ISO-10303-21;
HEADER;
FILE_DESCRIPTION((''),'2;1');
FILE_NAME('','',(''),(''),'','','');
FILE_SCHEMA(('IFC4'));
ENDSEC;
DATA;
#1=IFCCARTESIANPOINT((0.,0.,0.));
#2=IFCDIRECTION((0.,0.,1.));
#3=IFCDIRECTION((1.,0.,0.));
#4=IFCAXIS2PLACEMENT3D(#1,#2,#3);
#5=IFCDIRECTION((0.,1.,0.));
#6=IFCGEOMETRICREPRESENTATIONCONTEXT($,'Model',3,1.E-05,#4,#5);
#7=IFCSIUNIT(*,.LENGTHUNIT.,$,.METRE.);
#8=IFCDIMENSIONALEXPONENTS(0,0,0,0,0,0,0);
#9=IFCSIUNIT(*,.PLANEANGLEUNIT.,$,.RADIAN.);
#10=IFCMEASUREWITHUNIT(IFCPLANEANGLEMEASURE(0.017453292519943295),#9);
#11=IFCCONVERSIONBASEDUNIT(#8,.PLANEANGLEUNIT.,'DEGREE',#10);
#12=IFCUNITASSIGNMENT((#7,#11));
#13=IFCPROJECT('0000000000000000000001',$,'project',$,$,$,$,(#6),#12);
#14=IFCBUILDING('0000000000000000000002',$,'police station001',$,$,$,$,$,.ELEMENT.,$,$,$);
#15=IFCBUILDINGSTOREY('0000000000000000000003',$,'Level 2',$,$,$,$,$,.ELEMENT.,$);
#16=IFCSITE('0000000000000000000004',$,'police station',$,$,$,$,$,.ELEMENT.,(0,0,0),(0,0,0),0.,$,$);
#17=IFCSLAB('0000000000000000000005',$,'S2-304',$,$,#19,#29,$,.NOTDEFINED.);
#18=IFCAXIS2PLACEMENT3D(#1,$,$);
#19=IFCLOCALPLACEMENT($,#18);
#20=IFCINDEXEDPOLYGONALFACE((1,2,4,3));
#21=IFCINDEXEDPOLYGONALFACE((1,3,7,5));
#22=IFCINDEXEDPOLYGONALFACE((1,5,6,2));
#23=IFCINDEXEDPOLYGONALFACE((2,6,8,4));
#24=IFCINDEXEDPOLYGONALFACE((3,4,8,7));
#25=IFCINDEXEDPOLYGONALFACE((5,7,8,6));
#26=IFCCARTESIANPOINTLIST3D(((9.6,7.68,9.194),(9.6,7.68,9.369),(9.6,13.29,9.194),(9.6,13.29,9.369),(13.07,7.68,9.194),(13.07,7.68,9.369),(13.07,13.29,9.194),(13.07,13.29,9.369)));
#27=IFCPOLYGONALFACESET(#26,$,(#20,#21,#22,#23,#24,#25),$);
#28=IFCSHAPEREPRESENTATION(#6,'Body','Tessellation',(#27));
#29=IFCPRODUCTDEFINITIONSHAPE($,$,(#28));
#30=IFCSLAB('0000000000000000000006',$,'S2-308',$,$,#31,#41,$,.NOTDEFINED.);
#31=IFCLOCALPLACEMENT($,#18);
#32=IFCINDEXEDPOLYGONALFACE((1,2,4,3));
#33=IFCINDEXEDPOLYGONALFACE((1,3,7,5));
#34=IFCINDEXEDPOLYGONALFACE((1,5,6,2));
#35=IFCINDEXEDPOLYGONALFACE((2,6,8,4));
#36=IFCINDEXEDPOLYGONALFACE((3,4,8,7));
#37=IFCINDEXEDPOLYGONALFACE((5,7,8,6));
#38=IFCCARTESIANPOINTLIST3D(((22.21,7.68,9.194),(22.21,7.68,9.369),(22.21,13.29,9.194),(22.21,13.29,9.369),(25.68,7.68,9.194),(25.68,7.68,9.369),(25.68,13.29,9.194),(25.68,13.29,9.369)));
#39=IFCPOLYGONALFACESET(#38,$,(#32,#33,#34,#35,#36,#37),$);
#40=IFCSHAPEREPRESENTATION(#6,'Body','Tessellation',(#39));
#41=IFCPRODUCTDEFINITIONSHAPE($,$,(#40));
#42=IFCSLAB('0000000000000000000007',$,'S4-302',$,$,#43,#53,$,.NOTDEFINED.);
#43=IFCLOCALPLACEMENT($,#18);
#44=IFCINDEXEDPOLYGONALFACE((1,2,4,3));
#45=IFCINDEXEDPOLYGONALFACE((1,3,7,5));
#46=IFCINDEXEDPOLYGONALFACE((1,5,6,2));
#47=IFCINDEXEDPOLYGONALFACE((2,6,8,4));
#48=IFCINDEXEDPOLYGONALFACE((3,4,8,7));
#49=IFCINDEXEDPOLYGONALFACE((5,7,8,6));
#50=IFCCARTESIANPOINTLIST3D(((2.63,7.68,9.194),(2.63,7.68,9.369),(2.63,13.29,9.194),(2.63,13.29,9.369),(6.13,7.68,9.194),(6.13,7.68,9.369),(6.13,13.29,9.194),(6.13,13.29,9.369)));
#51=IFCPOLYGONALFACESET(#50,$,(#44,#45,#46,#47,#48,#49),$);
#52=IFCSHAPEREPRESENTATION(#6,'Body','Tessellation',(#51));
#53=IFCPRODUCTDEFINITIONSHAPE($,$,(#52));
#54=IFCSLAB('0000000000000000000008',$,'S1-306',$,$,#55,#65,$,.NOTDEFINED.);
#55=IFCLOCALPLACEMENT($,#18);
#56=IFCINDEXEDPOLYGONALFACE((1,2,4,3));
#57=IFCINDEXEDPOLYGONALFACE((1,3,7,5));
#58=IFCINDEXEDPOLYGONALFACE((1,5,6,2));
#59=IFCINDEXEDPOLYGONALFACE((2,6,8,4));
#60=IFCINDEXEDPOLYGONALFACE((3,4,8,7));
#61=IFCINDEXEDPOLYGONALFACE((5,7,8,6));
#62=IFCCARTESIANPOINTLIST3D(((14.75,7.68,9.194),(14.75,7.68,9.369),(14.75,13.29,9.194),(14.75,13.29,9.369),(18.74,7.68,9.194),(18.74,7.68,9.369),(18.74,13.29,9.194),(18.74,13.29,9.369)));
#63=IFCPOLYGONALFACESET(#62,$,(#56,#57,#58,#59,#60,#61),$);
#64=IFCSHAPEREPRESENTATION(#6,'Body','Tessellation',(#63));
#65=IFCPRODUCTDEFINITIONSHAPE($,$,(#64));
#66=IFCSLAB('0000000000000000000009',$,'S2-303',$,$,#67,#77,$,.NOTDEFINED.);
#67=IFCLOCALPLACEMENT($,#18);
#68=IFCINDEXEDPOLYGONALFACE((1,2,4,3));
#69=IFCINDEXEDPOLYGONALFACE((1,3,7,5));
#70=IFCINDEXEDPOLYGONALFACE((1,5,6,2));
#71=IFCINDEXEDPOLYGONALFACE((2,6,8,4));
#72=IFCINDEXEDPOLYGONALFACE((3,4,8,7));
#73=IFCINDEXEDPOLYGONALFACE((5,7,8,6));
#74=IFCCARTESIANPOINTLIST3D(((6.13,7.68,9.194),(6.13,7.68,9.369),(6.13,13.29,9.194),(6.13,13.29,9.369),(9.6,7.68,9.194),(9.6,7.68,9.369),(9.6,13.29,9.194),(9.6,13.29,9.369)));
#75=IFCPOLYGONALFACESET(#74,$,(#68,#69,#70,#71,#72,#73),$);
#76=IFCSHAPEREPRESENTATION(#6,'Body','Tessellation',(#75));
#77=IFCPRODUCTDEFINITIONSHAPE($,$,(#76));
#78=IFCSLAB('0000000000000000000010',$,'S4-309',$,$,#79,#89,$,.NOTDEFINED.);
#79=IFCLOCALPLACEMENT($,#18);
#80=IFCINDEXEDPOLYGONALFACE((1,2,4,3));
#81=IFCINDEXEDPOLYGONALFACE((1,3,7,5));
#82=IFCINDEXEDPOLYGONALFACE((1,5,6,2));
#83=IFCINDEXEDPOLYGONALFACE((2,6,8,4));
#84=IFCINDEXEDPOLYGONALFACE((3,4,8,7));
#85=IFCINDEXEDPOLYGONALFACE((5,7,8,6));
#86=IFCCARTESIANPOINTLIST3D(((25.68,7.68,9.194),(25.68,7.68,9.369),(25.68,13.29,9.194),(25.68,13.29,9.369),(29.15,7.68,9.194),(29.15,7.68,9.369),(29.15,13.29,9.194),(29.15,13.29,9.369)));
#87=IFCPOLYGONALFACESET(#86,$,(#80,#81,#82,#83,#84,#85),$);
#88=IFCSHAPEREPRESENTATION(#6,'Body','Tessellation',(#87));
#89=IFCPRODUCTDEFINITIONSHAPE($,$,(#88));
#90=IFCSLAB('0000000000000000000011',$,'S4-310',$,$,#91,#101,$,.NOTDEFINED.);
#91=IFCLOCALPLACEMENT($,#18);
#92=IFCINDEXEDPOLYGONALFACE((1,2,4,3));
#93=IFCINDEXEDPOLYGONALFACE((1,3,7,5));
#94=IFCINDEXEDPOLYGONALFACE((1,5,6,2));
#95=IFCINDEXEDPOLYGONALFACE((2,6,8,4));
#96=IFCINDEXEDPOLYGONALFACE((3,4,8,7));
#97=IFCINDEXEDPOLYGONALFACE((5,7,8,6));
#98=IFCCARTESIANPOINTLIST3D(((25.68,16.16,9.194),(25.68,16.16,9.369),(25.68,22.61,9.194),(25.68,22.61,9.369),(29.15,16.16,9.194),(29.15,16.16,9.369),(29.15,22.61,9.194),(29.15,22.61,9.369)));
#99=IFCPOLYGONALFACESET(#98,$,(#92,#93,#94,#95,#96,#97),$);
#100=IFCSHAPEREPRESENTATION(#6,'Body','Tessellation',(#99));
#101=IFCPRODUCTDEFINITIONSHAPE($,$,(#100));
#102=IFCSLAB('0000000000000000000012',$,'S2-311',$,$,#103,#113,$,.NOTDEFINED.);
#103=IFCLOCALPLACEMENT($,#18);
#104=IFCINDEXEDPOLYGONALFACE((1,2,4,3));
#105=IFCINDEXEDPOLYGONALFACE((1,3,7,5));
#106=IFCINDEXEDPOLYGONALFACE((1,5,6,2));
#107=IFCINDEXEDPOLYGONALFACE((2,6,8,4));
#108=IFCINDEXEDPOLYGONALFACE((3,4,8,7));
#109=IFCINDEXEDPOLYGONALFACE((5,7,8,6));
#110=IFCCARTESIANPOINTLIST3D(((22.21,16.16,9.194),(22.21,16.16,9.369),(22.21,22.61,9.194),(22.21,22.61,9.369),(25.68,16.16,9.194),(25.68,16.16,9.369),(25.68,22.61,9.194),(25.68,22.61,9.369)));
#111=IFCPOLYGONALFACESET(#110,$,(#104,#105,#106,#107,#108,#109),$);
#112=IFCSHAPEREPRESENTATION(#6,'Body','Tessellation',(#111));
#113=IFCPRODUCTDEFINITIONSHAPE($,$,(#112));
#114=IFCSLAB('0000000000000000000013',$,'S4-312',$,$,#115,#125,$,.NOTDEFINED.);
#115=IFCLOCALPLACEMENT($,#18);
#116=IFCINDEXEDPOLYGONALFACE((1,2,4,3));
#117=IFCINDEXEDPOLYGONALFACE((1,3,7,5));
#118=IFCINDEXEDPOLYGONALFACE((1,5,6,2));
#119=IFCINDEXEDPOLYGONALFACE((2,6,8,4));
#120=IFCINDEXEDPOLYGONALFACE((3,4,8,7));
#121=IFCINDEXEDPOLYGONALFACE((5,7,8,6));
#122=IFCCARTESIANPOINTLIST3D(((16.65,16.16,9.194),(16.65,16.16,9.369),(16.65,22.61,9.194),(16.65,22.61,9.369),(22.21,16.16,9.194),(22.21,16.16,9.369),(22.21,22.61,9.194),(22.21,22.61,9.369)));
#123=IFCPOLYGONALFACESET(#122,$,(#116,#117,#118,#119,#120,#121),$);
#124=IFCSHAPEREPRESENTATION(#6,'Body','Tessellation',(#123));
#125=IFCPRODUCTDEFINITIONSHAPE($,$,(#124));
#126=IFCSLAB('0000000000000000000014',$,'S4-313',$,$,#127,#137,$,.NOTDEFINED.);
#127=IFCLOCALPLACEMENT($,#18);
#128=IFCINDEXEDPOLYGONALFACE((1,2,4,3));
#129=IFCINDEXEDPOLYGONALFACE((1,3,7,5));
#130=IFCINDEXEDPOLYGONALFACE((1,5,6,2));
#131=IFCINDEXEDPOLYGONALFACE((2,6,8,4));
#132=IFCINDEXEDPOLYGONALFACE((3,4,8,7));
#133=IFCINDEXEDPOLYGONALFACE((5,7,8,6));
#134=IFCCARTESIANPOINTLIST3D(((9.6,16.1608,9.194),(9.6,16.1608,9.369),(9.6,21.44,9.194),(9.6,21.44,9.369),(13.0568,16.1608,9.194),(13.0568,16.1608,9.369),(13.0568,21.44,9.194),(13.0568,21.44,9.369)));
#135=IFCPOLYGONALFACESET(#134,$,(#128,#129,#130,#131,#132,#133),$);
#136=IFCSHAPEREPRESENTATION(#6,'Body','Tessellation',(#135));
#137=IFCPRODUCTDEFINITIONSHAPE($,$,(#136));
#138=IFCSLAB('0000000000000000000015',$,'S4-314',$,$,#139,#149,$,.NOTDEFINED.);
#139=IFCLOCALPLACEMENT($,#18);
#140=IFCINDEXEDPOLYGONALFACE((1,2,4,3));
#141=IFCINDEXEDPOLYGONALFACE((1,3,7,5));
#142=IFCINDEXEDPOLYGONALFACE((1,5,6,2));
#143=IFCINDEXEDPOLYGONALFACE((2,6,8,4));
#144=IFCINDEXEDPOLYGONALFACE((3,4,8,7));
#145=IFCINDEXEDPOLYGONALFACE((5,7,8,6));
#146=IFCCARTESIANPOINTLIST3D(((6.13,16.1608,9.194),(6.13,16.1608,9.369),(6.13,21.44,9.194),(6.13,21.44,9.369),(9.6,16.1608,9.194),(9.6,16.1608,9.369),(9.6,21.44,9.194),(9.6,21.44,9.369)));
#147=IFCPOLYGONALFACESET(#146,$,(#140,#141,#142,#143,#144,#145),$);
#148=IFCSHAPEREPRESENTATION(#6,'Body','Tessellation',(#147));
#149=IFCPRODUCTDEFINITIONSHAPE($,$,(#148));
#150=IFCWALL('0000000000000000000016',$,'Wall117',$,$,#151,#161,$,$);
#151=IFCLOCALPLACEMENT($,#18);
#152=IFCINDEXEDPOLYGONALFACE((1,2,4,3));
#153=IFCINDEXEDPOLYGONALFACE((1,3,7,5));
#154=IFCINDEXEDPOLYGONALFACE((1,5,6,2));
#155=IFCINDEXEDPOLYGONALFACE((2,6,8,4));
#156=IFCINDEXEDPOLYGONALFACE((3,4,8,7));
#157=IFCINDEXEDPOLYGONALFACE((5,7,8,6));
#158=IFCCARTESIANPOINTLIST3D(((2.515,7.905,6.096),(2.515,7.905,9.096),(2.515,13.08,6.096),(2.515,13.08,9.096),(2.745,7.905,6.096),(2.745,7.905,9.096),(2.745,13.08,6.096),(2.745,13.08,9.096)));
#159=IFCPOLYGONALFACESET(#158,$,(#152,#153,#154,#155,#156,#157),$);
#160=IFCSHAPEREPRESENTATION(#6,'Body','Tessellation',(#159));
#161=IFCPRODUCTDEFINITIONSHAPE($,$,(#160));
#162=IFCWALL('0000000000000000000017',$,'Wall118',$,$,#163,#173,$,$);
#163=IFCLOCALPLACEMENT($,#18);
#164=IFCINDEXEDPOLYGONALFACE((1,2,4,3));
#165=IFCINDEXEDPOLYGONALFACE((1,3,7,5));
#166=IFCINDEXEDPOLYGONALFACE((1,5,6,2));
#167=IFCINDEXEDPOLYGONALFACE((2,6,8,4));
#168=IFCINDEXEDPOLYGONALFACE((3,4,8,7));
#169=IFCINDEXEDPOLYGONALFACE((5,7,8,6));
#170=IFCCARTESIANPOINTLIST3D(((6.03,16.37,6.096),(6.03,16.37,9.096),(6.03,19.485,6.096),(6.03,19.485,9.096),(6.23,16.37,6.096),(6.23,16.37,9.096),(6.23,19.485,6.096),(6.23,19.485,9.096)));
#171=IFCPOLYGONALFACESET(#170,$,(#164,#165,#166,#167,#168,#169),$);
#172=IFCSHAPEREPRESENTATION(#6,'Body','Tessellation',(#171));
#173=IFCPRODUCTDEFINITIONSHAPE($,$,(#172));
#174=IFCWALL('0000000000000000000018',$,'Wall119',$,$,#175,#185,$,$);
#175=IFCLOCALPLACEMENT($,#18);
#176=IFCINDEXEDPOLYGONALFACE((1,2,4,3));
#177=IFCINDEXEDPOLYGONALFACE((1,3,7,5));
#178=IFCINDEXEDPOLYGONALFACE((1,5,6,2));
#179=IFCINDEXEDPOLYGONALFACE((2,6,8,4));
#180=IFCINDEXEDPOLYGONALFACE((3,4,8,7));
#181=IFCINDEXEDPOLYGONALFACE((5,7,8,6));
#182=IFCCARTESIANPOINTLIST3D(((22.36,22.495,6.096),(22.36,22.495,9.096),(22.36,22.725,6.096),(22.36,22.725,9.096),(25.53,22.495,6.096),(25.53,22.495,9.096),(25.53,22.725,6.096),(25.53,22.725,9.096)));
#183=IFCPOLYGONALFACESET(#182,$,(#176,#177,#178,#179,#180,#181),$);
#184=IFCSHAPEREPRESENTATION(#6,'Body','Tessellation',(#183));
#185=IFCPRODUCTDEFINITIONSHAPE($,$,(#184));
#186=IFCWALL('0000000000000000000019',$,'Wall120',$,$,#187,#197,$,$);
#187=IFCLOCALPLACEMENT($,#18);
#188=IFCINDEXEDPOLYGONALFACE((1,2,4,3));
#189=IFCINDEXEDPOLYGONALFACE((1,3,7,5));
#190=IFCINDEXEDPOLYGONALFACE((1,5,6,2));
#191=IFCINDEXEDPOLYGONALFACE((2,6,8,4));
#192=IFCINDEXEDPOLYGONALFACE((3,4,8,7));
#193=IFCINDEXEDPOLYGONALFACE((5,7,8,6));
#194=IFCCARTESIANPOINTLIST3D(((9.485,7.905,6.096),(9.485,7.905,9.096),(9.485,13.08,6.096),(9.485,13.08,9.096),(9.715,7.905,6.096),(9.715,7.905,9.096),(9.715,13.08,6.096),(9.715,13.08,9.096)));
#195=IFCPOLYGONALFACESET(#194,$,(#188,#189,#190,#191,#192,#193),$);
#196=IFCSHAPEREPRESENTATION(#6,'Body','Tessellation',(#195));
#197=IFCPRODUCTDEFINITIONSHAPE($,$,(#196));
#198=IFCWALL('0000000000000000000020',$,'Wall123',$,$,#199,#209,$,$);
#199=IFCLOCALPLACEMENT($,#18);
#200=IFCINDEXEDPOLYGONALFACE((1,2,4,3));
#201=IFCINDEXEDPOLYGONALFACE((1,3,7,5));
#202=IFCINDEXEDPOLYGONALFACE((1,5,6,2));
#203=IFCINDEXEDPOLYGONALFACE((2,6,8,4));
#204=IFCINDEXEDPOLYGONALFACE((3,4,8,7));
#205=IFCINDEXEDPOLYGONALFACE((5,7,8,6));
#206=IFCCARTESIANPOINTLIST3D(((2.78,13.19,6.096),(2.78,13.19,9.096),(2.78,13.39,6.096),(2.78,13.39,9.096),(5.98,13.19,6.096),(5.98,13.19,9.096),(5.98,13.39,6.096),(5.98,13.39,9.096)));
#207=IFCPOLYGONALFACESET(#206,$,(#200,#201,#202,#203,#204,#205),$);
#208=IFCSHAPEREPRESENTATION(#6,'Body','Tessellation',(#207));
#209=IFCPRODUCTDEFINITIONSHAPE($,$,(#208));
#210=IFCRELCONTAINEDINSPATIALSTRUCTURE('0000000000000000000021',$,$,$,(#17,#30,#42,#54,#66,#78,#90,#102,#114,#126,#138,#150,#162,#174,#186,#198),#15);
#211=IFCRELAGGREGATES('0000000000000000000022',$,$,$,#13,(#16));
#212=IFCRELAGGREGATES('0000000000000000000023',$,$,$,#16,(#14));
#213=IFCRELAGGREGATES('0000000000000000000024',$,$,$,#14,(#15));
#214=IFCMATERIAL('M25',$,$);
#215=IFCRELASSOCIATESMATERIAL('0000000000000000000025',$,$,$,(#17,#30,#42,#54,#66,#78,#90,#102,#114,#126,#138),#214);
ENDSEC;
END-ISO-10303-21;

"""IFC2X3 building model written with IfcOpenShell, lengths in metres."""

from ifc_helpers import new_model, entity, si_unit, converted_unit, direction, frame, frame_2d, origin_with_axes, place, context, project, spatial, rectangle, extrude, material, element, save


model = new_model("IFC2X3")

# Units and contexts
model_context = context("Model", 3, precision=1e-05, world=origin_with_axes(), true_north=direction((0.0, 1.0, 0.0)))
ifc_project = project(units=[si_unit("LENGTHUNIT", "METRE"), converted_unit("PLANEANGLEUNIT", "DEGREE", entity("IfcPlaneAngleMeasure", 0.017453292519943295), si_unit("PLANEANGLEUNIT", "RADIAN"), dimensions=[0, 0, 0, 0, 0, 0, 0])], contexts=[model_context])

# Site, building, storey
site = spatial("IfcSite", under=ifc_project, Name="police station", CompositionType="ELEMENT", RefLatitude=(0, 0, 0), RefLongitude=(0, 0, 0), RefElevation=0.0)
building = spatial("IfcBuilding", under=site, Name="police station001", CompositionType="ELEMENT")
storey = spatial("IfcBuildingStorey", under=building, Name="Level 2", CompositionType="ELEMENT")

# Slabs
ifc_material = material(Name="M25")
placement = place(None, origin_with_axes())
element("IfcSlab", 1, at=placement, inside=storey, material=ifc_material, Name="S2-304", PredefinedType="NOTDEFINED", context=model_context, shape_type="SweptSolid", body=[
    extrude(rectangle(XDim=3.47, YDim=5.61, at=frame_2d((0.0, 0.0), x_axis=(1.0, 0.0, 0.0))), frame((11.335, 10.485, 9.194), z_axis=(0.0, 0.0, 1.0), x_axis=(1.0, 0.0, 0.0)), (0.0, 0.0, 1.0), 0.175),
])
element("IfcSlab", 2, at=placement, inside=storey, material=ifc_material, Name="S2-308", PredefinedType="NOTDEFINED", context=model_context, shape_type="SweptSolid", body=[
    extrude(rectangle(XDim=3.47, YDim=5.61, at=frame_2d((0.0, 0.0), x_axis=(1.0, 0.0, 0.0))), frame((23.945, 10.485, 9.194), z_axis=(0.0, 0.0, 1.0), x_axis=(1.0, 0.0, 0.0)), (0.0, 0.0, 1.0), 0.175),
])
element("IfcSlab", 3, at=placement, inside=storey, material=ifc_material, Name="S4-302", PredefinedType="NOTDEFINED", context=model_context, shape_type="SweptSolid", body=[
    extrude(rectangle(XDim=3.5, YDim=5.61, at=frame_2d((0.0, 0.0), x_axis=(1.0, 0.0, 0.0))), frame((4.38, 10.485, 9.194), z_axis=(0.0, 0.0, 1.0), x_axis=(1.0, 0.0, 0.0)), (0.0, 0.0, 1.0), 0.175),
])
element("IfcSlab", 4, at=placement, inside=storey, material=ifc_material, Name="S1-306", PredefinedType="NOTDEFINED", context=model_context, shape_type="SweptSolid", body=[
    extrude(rectangle(XDim=3.99, YDim=5.61, at=frame_2d((0.0, 0.0), x_axis=(1.0, 0.0, 0.0))), frame((16.745, 10.485, 9.194), z_axis=(0.0, 0.0, 1.0), x_axis=(1.0, 0.0, 0.0)), (0.0, 0.0, 1.0), 0.175),
])
element("IfcSlab", 5, at=placement, inside=storey, material=ifc_material, Name="S2-303", PredefinedType="NOTDEFINED", context=model_context, shape_type="SweptSolid", body=[
    extrude(rectangle(XDim=3.47, YDim=5.61, at=frame_2d((0.0, 0.0), x_axis=(1.0, 0.0, 0.0))), frame((7.865, 10.485, 9.194), z_axis=(0.0, 0.0, 1.0), x_axis=(1.0, 0.0, 0.0)), (0.0, 0.0, 1.0), 0.175),
])
element("IfcSlab", 6, at=placement, inside=storey, material=ifc_material, Name="S4-309", PredefinedType="NOTDEFINED", context=model_context, shape_type="SweptSolid", body=[
    extrude(rectangle(XDim=3.47, YDim=5.61, at=frame_2d((0.0, 0.0), x_axis=(1.0, 0.0, 0.0))), frame((27.415, 10.485, 9.194), z_axis=(0.0, 0.0, 1.0), x_axis=(1.0, 0.0, 0.0)), (0.0, 0.0, 1.0), 0.175),
])
element("IfcSlab", 7, at=placement, inside=storey, material=ifc_material, Name="S4-310", PredefinedType="NOTDEFINED", context=model_context, shape_type="SweptSolid", body=[
    extrude(rectangle(XDim=3.47, YDim=6.45, at=frame_2d((0.0, 0.0), x_axis=(1.0, 0.0, 0.0))), frame((27.415, 19.385, 9.194), z_axis=(0.0, 0.0, 1.0), x_axis=(1.0, 0.0, 0.0)), (0.0, 0.0, 1.0), 0.175),
])
element("IfcSlab", 8, at=placement, inside=storey, material=ifc_material, Name="S2-311", PredefinedType="NOTDEFINED", context=model_context, shape_type="SweptSolid", body=[
    extrude(rectangle(XDim=3.47, YDim=6.45, at=frame_2d((0.0, 0.0), x_axis=(1.0, 0.0, 0.0))), frame((23.945, 19.385, 9.194), z_axis=(0.0, 0.0, 1.0), x_axis=(1.0, 0.0, 0.0)), (0.0, 0.0, 1.0), 0.175),
])
element("IfcSlab", 9, at=placement, inside=storey, material=ifc_material, Name="S4-312", PredefinedType="NOTDEFINED", context=model_context, shape_type="SweptSolid", body=[
    extrude(rectangle(XDim=5.56, YDim=6.45, at=frame_2d((0.0, 0.0), x_axis=(1.0, 0.0, 0.0))), frame((19.43, 19.385, 9.194), z_axis=(0.0, 0.0, 1.0), x_axis=(1.0, 0.0, 0.0)), (0.0, 0.0, 1.0), 0.175),
])
element("IfcSlab", 10, at=placement, inside=storey, material=ifc_material, Name="S4-313", PredefinedType="NOTDEFINED", context=model_context, shape_type="SweptSolid", body=[
    extrude(rectangle(XDim=3.4568, YDim=5.2792, at=frame_2d((0.0, 0.0), x_axis=(1.0, 0.0, 0.0))), frame((11.3284, 18.8004, 9.194), z_axis=(0.0, 0.0, 1.0), x_axis=(1.0, 0.0, 0.0)), (0.0, 0.0, 1.0), 0.175),
])
element("IfcSlab", 11, at=placement, inside=storey, material=ifc_material, Name="S4-314", PredefinedType="NOTDEFINED", context=model_context, shape_type="SweptSolid", body=[
    extrude(rectangle(XDim=3.47, YDim=5.2792, at=frame_2d((0.0, 0.0), x_axis=(1.0, 0.0, 0.0))), frame((7.865, 18.8004, 9.194), z_axis=(0.0, 0.0, 1.0), x_axis=(1.0, 0.0, 0.0)), (0.0, 0.0, 1.0), 0.175),
])

# Walls
element("IfcWall", 12, at=placement, inside=storey, Name="Wall117", context=model_context, shape_type="SweptSolid", body=[
    extrude(rectangle(XDim=5.175, YDim=0.23, at=frame_2d((0.0, 0.0), x_axis=(0.0, -1.0, 0.0))), frame((2.63, 10.4925, 6.096), z_axis=(0.0, 0.0, 1.0), x_axis=(1.0, 0.0, 0.0)), (0.0, 0.0, 1.0), 3.0),
])
element("IfcWall", 13, at=placement, inside=storey, Name="Wall118", context=model_context, shape_type="SweptSolid", body=[
    extrude(rectangle(XDim=3.115, YDim=0.2, at=frame_2d((0.0, 0.0), x_axis=(0.0, -1.0, 0.0))), frame((6.13, 17.9275, 6.096), z_axis=(0.0, 0.0, 1.0), x_axis=(1.0, 0.0, 0.0)), (0.0, 0.0, 1.0), 3.0),
])
element("IfcWall", 14, at=placement, inside=storey, Name="Wall119", context=model_context, shape_type="SweptSolid", body=[
    extrude(rectangle(XDim=3.17, YDim=0.23, at=frame_2d((0.0, 0.0), x_axis=(-1.0, 0.0, 0.0))), frame((23.945, 22.61, 6.096), z_axis=(0.0, 0.0, 1.0), x_axis=(1.0, 0.0, 0.0)), (0.0, 0.0, 1.0), 3.0),
])
element("IfcWall", 15, at=placement, inside=storey, Name="Wall120", context=model_context, shape_type="SweptSolid", body=[
    extrude(rectangle(XDim=5.175, YDim=0.23, at=frame_2d((0.0, 0.0), x_axis=(0.0, -1.0, 0.0))), frame((9.6, 10.4925, 6.096), z_axis=(0.0, 0.0, 1.0), x_axis=(1.0, 0.0, 0.0)), (0.0, 0.0, 1.0), 3.0),
])
element("IfcWall", 16, at=placement, inside=storey, Name="Wall123", context=model_context, shape_type="SweptSolid", body=[
    extrude(rectangle(XDim=3.2, YDim=0.2, at=frame_2d((0.0, 0.0), x_axis=(1.0, 0.0, 0.0))), frame((4.38, 13.29, 6.096), z_axis=(0.0, 0.0, 1.0), x_axis=(1.0, 0.0, 0.0)), (0.0, 0.0, 1.0), 3.0),
])

save(model, "model.ifc")
